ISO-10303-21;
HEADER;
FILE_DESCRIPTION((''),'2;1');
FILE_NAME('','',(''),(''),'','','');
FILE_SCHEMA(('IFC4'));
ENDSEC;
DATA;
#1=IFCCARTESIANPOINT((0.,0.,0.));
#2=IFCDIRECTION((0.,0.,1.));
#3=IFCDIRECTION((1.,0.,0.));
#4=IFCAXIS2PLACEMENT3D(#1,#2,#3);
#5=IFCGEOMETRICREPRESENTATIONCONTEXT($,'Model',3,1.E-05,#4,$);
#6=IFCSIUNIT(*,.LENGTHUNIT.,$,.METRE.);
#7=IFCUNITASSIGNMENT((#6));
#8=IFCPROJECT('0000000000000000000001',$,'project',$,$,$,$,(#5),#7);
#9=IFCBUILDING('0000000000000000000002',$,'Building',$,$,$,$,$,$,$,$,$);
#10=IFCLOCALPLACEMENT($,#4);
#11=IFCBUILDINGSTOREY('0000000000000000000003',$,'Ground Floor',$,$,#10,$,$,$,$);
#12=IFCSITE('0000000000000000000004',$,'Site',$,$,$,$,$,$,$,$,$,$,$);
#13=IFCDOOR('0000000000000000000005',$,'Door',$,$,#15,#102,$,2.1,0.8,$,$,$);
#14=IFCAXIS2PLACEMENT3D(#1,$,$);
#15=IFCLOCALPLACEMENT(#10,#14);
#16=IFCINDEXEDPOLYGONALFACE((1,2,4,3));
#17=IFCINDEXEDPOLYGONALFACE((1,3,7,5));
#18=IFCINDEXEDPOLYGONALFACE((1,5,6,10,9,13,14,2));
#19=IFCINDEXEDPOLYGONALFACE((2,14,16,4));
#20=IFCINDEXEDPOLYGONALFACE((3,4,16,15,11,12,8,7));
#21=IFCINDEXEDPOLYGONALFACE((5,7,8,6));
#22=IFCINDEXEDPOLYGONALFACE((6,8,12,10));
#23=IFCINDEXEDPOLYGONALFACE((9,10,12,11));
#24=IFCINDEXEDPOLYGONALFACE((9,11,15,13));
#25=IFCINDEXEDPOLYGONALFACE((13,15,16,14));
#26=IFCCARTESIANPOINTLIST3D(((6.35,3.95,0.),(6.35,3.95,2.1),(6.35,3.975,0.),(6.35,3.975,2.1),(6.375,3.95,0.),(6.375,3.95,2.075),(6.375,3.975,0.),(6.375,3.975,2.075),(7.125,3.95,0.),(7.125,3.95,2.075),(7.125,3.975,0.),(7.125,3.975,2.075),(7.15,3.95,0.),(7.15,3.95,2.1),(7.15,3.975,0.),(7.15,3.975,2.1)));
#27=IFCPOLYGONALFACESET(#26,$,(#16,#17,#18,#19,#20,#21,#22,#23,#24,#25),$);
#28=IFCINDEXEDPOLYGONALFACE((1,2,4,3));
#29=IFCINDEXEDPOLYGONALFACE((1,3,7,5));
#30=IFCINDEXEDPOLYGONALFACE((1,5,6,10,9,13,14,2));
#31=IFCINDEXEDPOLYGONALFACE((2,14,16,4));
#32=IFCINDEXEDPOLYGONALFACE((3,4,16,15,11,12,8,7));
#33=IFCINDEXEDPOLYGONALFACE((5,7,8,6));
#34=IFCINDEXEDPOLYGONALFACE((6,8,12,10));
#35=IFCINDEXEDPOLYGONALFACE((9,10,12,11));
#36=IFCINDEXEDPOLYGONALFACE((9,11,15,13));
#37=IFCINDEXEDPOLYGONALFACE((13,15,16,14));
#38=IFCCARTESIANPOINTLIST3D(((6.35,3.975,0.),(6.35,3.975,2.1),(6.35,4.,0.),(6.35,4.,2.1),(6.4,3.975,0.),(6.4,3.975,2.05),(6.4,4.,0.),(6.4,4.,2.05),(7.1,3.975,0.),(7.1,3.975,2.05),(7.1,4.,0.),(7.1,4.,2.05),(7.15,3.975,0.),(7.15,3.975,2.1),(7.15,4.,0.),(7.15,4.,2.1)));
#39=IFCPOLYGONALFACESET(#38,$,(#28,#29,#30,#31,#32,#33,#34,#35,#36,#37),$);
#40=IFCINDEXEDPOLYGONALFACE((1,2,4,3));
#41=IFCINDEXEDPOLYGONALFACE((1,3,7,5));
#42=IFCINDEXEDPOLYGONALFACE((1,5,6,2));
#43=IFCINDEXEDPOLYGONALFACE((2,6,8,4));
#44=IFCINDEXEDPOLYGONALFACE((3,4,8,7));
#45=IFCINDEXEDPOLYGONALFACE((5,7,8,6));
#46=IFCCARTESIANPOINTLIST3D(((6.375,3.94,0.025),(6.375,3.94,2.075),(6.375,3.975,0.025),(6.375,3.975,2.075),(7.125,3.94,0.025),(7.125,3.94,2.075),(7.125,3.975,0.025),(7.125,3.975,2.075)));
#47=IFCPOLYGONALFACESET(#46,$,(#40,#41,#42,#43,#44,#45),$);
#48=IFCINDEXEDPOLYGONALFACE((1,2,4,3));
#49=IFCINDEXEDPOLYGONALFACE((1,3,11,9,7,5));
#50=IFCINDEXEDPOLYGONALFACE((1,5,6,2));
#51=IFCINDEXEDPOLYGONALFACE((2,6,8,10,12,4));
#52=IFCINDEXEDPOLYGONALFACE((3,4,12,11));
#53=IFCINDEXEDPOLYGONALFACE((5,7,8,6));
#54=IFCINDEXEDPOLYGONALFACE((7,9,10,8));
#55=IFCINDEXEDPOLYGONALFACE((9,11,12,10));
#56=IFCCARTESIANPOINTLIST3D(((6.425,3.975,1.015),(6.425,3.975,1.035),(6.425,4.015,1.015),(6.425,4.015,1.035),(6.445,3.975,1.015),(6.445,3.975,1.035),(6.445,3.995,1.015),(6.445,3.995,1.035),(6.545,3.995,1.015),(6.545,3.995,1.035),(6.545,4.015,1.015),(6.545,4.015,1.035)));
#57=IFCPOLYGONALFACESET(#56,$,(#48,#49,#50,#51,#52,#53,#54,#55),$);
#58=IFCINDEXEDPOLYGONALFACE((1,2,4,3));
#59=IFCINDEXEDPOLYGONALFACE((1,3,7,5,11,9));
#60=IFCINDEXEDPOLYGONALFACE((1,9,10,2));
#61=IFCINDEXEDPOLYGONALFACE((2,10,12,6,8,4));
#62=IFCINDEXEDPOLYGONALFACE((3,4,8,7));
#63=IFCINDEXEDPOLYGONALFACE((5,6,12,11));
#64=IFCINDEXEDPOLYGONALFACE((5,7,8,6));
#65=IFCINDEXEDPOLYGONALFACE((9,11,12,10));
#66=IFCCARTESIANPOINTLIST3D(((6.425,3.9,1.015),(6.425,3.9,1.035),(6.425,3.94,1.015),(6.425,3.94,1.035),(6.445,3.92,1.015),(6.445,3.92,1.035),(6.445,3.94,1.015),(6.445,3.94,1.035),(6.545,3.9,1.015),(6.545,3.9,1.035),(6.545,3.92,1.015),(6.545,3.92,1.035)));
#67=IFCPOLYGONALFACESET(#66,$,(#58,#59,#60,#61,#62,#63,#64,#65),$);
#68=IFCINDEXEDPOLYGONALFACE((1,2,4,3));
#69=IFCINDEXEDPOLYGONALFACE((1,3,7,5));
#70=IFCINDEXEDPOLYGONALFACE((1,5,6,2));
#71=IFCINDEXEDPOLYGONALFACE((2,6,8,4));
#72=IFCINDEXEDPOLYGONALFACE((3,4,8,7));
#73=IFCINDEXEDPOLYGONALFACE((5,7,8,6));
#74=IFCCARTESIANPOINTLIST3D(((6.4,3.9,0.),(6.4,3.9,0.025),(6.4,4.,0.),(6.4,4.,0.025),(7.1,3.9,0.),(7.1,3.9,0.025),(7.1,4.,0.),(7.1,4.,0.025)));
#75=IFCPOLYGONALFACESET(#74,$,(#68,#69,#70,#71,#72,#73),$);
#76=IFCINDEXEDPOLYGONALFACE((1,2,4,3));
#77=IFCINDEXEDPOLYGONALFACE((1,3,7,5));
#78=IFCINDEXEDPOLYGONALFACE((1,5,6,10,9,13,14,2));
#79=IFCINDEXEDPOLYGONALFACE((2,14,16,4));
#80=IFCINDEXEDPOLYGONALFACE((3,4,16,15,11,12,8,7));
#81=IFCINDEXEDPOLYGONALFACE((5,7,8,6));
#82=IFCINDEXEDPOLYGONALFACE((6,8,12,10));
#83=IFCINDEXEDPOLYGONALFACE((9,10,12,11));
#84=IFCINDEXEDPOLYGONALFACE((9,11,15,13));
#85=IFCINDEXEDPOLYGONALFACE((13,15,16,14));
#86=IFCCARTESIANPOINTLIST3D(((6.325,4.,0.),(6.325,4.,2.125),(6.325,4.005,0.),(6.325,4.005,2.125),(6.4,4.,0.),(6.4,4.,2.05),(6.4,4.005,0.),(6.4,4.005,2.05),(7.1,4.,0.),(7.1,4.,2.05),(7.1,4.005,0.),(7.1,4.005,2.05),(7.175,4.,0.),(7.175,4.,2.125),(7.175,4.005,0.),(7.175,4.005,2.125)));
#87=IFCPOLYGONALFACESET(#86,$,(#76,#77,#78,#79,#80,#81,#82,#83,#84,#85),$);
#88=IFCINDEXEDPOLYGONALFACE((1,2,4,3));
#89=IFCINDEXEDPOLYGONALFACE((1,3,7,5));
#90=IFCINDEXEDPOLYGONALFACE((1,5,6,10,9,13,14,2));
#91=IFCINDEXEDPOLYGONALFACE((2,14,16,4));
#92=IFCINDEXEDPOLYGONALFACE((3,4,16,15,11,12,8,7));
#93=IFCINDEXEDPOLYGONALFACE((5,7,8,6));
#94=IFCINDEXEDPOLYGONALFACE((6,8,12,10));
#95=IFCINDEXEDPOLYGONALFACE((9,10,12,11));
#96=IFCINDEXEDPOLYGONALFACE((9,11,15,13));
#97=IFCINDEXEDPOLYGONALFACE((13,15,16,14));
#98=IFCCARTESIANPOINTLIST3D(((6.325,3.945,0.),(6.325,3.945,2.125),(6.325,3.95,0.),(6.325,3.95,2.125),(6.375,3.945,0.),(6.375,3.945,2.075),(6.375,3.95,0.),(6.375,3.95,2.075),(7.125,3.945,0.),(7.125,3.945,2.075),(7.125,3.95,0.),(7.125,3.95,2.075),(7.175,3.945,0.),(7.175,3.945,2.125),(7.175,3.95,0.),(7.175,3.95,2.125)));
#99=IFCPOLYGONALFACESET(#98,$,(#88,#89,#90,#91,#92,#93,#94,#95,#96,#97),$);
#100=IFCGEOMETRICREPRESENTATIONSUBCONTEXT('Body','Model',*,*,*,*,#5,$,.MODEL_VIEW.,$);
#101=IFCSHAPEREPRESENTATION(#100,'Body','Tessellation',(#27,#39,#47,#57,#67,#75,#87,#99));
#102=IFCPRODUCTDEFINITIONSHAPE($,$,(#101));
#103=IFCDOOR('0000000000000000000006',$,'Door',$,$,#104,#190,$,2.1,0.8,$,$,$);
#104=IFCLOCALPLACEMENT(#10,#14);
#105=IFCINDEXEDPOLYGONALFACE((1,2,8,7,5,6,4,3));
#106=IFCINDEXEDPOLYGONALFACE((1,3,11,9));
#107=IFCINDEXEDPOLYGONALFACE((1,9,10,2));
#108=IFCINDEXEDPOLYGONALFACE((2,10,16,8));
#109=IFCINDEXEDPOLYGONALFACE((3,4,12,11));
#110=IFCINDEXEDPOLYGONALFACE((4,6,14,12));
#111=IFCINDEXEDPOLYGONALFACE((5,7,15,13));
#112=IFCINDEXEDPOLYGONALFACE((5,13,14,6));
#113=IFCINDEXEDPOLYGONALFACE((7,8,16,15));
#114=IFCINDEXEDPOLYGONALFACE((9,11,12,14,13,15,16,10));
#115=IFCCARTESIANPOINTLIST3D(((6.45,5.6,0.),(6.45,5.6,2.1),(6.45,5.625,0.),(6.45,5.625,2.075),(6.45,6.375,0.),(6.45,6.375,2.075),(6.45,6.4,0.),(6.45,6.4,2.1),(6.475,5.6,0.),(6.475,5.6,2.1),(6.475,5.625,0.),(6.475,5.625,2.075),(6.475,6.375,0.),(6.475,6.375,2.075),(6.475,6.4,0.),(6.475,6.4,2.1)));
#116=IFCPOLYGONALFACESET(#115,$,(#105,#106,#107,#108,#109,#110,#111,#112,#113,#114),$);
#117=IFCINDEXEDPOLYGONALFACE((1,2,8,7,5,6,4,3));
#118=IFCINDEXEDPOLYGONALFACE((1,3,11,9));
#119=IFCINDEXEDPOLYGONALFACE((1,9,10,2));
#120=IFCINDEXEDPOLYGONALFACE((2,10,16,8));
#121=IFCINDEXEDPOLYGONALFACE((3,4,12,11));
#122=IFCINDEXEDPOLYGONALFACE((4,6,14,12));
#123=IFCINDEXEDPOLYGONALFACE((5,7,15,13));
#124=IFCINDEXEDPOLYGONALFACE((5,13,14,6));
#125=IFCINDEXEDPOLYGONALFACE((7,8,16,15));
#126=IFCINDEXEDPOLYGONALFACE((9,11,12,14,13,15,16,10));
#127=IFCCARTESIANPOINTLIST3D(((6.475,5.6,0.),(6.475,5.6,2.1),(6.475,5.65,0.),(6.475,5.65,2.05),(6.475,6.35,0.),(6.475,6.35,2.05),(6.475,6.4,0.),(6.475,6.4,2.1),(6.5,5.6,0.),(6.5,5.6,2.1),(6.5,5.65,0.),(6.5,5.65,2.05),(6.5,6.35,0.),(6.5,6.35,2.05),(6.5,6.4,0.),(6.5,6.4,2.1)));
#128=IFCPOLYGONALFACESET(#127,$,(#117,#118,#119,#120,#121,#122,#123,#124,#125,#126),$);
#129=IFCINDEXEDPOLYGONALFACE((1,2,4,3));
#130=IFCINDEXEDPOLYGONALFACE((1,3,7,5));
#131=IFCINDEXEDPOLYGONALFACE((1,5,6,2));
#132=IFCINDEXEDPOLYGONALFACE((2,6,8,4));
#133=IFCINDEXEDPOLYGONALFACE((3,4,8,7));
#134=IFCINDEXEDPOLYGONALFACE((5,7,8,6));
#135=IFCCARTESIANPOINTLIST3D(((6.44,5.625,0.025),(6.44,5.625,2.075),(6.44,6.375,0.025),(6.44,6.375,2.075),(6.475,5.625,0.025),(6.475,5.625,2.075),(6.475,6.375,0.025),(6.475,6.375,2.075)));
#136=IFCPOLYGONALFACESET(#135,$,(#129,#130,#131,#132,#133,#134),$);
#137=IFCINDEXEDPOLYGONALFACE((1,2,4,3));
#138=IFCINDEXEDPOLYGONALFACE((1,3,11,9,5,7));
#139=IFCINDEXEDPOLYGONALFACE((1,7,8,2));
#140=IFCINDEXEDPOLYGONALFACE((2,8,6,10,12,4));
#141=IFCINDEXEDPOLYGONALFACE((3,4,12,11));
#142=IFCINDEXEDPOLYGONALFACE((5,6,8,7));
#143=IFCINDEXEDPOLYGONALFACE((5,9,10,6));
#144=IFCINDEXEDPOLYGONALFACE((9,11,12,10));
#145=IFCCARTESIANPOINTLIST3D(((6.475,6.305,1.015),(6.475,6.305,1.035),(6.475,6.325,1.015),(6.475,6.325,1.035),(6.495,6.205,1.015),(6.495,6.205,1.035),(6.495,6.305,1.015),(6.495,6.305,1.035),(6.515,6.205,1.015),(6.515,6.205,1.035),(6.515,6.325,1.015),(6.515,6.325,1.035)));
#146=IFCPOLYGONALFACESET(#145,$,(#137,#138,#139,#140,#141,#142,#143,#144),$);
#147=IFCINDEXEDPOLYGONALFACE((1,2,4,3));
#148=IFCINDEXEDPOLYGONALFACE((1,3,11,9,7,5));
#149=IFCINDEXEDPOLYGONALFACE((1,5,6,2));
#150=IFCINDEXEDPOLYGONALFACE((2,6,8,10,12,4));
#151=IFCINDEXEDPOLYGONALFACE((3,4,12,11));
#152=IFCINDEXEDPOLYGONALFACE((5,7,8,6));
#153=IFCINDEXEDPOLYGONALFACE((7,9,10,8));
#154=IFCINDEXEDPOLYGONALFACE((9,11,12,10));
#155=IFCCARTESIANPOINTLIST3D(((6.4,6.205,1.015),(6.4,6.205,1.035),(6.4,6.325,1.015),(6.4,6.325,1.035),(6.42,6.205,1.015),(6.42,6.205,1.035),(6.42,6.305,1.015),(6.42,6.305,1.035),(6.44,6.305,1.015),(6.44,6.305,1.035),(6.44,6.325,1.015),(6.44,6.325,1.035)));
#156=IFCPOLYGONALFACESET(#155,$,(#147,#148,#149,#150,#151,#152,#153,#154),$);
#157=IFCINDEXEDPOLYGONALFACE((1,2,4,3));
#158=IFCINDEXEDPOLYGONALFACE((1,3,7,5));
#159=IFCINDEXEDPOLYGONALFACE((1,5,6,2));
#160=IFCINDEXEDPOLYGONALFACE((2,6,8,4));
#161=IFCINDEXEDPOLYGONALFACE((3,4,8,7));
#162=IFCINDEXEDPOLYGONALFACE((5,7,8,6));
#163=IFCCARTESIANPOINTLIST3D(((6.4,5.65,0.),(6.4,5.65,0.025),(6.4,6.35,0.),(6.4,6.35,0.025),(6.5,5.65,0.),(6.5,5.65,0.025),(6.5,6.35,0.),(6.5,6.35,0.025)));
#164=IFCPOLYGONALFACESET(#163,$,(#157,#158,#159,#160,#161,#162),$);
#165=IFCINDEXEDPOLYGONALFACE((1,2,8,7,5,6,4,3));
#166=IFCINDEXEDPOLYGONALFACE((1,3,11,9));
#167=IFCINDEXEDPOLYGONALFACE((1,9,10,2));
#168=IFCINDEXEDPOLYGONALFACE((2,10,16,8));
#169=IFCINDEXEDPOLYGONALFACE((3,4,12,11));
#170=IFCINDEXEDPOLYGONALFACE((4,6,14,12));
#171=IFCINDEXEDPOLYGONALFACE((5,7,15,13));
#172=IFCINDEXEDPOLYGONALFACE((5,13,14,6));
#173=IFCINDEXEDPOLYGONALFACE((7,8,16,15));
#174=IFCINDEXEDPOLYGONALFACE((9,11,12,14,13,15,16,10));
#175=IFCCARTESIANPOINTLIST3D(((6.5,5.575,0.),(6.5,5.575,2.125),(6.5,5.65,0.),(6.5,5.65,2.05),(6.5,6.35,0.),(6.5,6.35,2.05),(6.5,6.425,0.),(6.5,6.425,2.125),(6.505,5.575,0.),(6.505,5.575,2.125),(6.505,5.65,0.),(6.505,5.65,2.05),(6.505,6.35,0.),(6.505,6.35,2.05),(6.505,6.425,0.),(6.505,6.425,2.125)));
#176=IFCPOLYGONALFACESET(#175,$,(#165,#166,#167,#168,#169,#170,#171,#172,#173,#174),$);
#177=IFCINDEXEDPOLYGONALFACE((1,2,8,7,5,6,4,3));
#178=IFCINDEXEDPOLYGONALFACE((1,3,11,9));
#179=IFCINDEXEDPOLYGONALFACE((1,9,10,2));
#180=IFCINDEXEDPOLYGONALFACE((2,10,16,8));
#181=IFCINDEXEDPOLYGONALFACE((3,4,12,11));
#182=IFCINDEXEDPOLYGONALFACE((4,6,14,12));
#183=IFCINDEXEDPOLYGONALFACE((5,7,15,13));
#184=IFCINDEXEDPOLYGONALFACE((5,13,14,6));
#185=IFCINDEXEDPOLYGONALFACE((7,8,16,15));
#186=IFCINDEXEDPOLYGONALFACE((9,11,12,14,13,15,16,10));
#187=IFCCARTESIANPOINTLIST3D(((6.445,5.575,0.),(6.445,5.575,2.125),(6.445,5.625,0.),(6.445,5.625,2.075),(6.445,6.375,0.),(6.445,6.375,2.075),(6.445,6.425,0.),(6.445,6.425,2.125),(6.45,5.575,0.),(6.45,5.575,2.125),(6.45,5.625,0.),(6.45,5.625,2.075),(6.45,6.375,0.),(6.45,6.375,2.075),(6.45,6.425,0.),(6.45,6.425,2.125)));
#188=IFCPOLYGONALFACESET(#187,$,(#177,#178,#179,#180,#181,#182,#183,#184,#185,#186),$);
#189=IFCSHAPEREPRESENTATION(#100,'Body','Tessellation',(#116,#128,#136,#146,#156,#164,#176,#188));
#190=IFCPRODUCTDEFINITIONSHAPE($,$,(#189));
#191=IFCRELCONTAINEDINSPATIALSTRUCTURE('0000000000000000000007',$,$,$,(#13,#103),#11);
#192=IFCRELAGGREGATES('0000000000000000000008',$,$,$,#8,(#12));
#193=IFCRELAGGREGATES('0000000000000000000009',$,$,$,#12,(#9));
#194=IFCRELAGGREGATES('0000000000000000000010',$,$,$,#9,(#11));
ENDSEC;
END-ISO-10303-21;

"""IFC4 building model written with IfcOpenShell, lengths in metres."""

from ifc_helpers import new_model, si_unit, frame, origin_with_axes, place, context, subcontext, project, spatial, line, indexed_curve, outline, extrude, element, save


model = new_model("IFC4")

# Units and contexts
model_context = context("Model", 3, precision=1e-05, world=origin_with_axes())
body_context = subcontext(model_context, "Body", "Model", "MODEL_VIEW")
ifc_project = project(units=[si_unit("LENGTHUNIT", "METRE")], contexts=[model_context])

# Site, building, storey
site = spatial("IfcSite", under=ifc_project, Name="Site")
building = spatial("IfcBuilding", under=site, Name="Building")
storey_placement = place(None, origin_with_axes())
storey = spatial("IfcBuildingStorey", under=building, at=storey_placement, Name="Ground Floor")

# Doors
door_1_placement = place(storey_placement, frame((7.15, 4.0, 0.0), z_axis=(0.0, 0.0, 1.0), x_axis=(-1.0, 0.0, 0.0)))
element("IfcDoor", 1, at=door_1_placement, inside=storey, Name="Door", OverallHeight=2.1, OverallWidth=0.8, context=body_context, shape_type="SweptSolid", body=[
    extrude(outline(indexed_curve([(0.0, 0.0), (0.0, 2.1), (0.8, 2.1), (0.8, 0.0), (0.775, 0.0), (0.775, 2.075), (0.025, 2.075), (0.025, 0.0)], segments=[line(1, 2, 3, 4, 5, 6, 7, 8, 1)])), frame((0.0, 0.025, 0.0), z_axis=(0.0, -1.0, 0.0), x_axis=(1.0, 0.0, 0.0)), (0.0, 0.0, -1.0), 0.025),
    extrude(outline(indexed_curve([(0.0, 0.0), (0.0, 2.1), (0.8, 2.1), (0.8, 0.0), (0.75, 0.0), (0.75, 2.05), (0.05, 2.05), (0.05, 0.0)], segments=[line(1, 2, 3, 4, 5, 6, 7, 8, 1)])), frame((0.0, 0.0, 0.0), z_axis=(0.0, -1.0, 0.0), x_axis=(1.0, 0.0, 0.0)), (0.0, 0.0, -1.0), 0.025),
    extrude(outline(indexed_curve([(0.0, 0.0), (0.75, 0.0), (0.75, 0.035), (0.0, 0.035)], segments=[line(1, 2, 3, 4, 1)])), frame((0.025, 0.025, 0.025), z_axis=(0.0, 0.0, 1.0), x_axis=(1.0, 0.0, 0.0)), (0.0, 0.0, 1.0), 2.05),
    extrude(outline(indexed_curve([(0.0, 0.0), (0.0, -0.04), (-0.12, -0.04), (-0.12, -0.02), (-0.02, -0.02), (-0.02, 0.0)], segments=[line(1, 2, 3, 4, 5, 6, 1)])), frame((0.725, 0.025, 1.015), z_axis=(0.0, 0.0, 1.0), x_axis=(1.0, 0.0, 0.0)), (0.0, 0.0, 1.0), 0.02),
    extrude(outline(indexed_curve([(0.0, 0.0), (0.0, 0.04), (-0.12, 0.04), (-0.12, 0.02), (-0.02, 0.02), (-0.02, 0.0)], segments=[line(1, 2, 3, 4, 5, 6, 1)])), frame((0.725, 0.06, 1.015), z_axis=(0.0, 0.0, 1.0), x_axis=(1.0, 0.0, 0.0)), (0.0, 0.0, 1.0), 0.02),
    extrude(outline(indexed_curve([(0.0, 0.0), (0.7, 0.0), (0.7, 0.1), (0.0, 0.1)], segments=[line(1, 2, 3, 4, 1)])), frame((0.05, 0.0, 0.0), z_axis=(0.0, 0.0, 1.0), x_axis=(1.0, 0.0, 0.0)), (0.0, 0.0, 1.0), 0.025),
    extrude(outline(indexed_curve([(0.0, 0.0), (0.0, 2.125), (0.85, 2.125), (0.85, 0.0), (0.775, 0.0), (0.775, 2.05), (0.075, 2.05), (0.075, 0.0)], segments=[line(1, 2, 3, 4, 5, 6, 7, 8, 1)])), frame((-0.025, -0.005, 0.0), z_axis=(0.0, -1.0, 0.0), x_axis=(1.0, 0.0, 0.0)), (0.0, 0.0, -1.0), 0.005),
    extrude(outline(indexed_curve([(0.0, 0.0), (0.0, 2.125), (0.85, 2.125), (0.85, 0.0), (0.8, 0.0), (0.8, 2.075), (0.05, 2.075), (0.05, 0.0)], segments=[line(1, 2, 3, 4, 5, 6, 7, 8, 1)])), frame((-0.025, 0.05, 0.0), z_axis=(0.0, -1.0, 0.0), x_axis=(1.0, 0.0, 0.0)), (0.0, 0.0, -1.0), 0.005),
])
door_2_placement = place(storey_placement, frame((6.5, 5.6, 0.0), z_axis=(0.0, 0.0, 1.0), x_axis=(0.0, 1.0, 0.0)))
element("IfcDoor", 2, at=door_2_placement, inside=storey, Name="Door", OverallHeight=2.1, OverallWidth=0.8, context=body_context, shape_type="SweptSolid", body=[
    extrude(outline(indexed_curve([(0.0, 0.0), (0.0, 2.1), (0.8, 2.1), (0.8, 0.0), (0.775, 0.0), (0.775, 2.075), (0.025, 2.075), (0.025, 0.0)], segments=[line(1, 2, 3, 4, 5, 6, 7, 8, 1)])), frame((0.0, 0.025, 0.0), z_axis=(0.0, -1.0, 0.0), x_axis=(1.0, 0.0, 0.0)), (0.0, 0.0, -1.0), 0.025),
    extrude(outline(indexed_curve([(0.0, 0.0), (0.0, 2.1), (0.8, 2.1), (0.8, 0.0), (0.75, 0.0), (0.75, 2.05), (0.05, 2.05), (0.05, 0.0)], segments=[line(1, 2, 3, 4, 5, 6, 7, 8, 1)])), frame((0.0, 0.0, 0.0), z_axis=(0.0, -1.0, 0.0), x_axis=(1.0, 0.0, 0.0)), (0.0, 0.0, -1.0), 0.025),
    extrude(outline(indexed_curve([(0.0, 0.0), (0.75, 0.0), (0.75, 0.035), (0.0, 0.035)], segments=[line(1, 2, 3, 4, 1)])), frame((0.025, 0.025, 0.025), z_axis=(0.0, 0.0, 1.0), x_axis=(1.0, 0.0, 0.0)), (0.0, 0.0, 1.0), 2.05),
    extrude(outline(indexed_curve([(0.0, 0.0), (0.0, -0.04), (-0.12, -0.04), (-0.12, -0.02), (-0.02, -0.02), (-0.02, 0.0)], segments=[line(1, 2, 3, 4, 5, 6, 1)])), frame((0.725, 0.025, 1.015), z_axis=(0.0, 0.0, 1.0), x_axis=(1.0, 0.0, 0.0)), (0.0, 0.0, 1.0), 0.02),
    extrude(outline(indexed_curve([(0.0, 0.0), (0.0, 0.04), (-0.12, 0.04), (-0.12, 0.02), (-0.02, 0.02), (-0.02, 0.0)], segments=[line(1, 2, 3, 4, 5, 6, 1)])), frame((0.725, 0.06, 1.015), z_axis=(0.0, 0.0, 1.0), x_axis=(1.0, 0.0, 0.0)), (0.0, 0.0, 1.0), 0.02),
    extrude(outline(indexed_curve([(0.0, 0.0), (0.7, 0.0), (0.7, 0.1), (0.0, 0.1)], segments=[line(1, 2, 3, 4, 1)])), frame((0.05, 0.0, 0.0), z_axis=(0.0, 0.0, 1.0), x_axis=(1.0, 0.0, 0.0)), (0.0, 0.0, 1.0), 0.025),
    extrude(outline(indexed_curve([(0.0, 0.0), (0.0, 2.125), (0.85, 2.125), (0.85, 0.0), (0.775, 0.0), (0.775, 2.05), (0.075, 2.05), (0.075, 0.0)], segments=[line(1, 2, 3, 4, 5, 6, 7, 8, 1)])), frame((-0.025, -0.005, 0.0), z_axis=(0.0, -1.0, 0.0), x_axis=(1.0, 0.0, 0.0)), (0.0, 0.0, -1.0), 0.005),
    extrude(outline(indexed_curve([(0.0, 0.0), (0.0, 2.125), (0.85, 2.125), (0.85, 0.0), (0.8, 0.0), (0.8, 2.075), (0.05, 2.075), (0.05, 0.0)], segments=[line(1, 2, 3, 4, 5, 6, 7, 8, 1)])), frame((-0.025, 0.05, 0.0), z_axis=(0.0, -1.0, 0.0), x_axis=(1.0, 0.0, 0.0)), (0.0, 0.0, -1.0), 0.005),
])

save(model, "model.ifc")
